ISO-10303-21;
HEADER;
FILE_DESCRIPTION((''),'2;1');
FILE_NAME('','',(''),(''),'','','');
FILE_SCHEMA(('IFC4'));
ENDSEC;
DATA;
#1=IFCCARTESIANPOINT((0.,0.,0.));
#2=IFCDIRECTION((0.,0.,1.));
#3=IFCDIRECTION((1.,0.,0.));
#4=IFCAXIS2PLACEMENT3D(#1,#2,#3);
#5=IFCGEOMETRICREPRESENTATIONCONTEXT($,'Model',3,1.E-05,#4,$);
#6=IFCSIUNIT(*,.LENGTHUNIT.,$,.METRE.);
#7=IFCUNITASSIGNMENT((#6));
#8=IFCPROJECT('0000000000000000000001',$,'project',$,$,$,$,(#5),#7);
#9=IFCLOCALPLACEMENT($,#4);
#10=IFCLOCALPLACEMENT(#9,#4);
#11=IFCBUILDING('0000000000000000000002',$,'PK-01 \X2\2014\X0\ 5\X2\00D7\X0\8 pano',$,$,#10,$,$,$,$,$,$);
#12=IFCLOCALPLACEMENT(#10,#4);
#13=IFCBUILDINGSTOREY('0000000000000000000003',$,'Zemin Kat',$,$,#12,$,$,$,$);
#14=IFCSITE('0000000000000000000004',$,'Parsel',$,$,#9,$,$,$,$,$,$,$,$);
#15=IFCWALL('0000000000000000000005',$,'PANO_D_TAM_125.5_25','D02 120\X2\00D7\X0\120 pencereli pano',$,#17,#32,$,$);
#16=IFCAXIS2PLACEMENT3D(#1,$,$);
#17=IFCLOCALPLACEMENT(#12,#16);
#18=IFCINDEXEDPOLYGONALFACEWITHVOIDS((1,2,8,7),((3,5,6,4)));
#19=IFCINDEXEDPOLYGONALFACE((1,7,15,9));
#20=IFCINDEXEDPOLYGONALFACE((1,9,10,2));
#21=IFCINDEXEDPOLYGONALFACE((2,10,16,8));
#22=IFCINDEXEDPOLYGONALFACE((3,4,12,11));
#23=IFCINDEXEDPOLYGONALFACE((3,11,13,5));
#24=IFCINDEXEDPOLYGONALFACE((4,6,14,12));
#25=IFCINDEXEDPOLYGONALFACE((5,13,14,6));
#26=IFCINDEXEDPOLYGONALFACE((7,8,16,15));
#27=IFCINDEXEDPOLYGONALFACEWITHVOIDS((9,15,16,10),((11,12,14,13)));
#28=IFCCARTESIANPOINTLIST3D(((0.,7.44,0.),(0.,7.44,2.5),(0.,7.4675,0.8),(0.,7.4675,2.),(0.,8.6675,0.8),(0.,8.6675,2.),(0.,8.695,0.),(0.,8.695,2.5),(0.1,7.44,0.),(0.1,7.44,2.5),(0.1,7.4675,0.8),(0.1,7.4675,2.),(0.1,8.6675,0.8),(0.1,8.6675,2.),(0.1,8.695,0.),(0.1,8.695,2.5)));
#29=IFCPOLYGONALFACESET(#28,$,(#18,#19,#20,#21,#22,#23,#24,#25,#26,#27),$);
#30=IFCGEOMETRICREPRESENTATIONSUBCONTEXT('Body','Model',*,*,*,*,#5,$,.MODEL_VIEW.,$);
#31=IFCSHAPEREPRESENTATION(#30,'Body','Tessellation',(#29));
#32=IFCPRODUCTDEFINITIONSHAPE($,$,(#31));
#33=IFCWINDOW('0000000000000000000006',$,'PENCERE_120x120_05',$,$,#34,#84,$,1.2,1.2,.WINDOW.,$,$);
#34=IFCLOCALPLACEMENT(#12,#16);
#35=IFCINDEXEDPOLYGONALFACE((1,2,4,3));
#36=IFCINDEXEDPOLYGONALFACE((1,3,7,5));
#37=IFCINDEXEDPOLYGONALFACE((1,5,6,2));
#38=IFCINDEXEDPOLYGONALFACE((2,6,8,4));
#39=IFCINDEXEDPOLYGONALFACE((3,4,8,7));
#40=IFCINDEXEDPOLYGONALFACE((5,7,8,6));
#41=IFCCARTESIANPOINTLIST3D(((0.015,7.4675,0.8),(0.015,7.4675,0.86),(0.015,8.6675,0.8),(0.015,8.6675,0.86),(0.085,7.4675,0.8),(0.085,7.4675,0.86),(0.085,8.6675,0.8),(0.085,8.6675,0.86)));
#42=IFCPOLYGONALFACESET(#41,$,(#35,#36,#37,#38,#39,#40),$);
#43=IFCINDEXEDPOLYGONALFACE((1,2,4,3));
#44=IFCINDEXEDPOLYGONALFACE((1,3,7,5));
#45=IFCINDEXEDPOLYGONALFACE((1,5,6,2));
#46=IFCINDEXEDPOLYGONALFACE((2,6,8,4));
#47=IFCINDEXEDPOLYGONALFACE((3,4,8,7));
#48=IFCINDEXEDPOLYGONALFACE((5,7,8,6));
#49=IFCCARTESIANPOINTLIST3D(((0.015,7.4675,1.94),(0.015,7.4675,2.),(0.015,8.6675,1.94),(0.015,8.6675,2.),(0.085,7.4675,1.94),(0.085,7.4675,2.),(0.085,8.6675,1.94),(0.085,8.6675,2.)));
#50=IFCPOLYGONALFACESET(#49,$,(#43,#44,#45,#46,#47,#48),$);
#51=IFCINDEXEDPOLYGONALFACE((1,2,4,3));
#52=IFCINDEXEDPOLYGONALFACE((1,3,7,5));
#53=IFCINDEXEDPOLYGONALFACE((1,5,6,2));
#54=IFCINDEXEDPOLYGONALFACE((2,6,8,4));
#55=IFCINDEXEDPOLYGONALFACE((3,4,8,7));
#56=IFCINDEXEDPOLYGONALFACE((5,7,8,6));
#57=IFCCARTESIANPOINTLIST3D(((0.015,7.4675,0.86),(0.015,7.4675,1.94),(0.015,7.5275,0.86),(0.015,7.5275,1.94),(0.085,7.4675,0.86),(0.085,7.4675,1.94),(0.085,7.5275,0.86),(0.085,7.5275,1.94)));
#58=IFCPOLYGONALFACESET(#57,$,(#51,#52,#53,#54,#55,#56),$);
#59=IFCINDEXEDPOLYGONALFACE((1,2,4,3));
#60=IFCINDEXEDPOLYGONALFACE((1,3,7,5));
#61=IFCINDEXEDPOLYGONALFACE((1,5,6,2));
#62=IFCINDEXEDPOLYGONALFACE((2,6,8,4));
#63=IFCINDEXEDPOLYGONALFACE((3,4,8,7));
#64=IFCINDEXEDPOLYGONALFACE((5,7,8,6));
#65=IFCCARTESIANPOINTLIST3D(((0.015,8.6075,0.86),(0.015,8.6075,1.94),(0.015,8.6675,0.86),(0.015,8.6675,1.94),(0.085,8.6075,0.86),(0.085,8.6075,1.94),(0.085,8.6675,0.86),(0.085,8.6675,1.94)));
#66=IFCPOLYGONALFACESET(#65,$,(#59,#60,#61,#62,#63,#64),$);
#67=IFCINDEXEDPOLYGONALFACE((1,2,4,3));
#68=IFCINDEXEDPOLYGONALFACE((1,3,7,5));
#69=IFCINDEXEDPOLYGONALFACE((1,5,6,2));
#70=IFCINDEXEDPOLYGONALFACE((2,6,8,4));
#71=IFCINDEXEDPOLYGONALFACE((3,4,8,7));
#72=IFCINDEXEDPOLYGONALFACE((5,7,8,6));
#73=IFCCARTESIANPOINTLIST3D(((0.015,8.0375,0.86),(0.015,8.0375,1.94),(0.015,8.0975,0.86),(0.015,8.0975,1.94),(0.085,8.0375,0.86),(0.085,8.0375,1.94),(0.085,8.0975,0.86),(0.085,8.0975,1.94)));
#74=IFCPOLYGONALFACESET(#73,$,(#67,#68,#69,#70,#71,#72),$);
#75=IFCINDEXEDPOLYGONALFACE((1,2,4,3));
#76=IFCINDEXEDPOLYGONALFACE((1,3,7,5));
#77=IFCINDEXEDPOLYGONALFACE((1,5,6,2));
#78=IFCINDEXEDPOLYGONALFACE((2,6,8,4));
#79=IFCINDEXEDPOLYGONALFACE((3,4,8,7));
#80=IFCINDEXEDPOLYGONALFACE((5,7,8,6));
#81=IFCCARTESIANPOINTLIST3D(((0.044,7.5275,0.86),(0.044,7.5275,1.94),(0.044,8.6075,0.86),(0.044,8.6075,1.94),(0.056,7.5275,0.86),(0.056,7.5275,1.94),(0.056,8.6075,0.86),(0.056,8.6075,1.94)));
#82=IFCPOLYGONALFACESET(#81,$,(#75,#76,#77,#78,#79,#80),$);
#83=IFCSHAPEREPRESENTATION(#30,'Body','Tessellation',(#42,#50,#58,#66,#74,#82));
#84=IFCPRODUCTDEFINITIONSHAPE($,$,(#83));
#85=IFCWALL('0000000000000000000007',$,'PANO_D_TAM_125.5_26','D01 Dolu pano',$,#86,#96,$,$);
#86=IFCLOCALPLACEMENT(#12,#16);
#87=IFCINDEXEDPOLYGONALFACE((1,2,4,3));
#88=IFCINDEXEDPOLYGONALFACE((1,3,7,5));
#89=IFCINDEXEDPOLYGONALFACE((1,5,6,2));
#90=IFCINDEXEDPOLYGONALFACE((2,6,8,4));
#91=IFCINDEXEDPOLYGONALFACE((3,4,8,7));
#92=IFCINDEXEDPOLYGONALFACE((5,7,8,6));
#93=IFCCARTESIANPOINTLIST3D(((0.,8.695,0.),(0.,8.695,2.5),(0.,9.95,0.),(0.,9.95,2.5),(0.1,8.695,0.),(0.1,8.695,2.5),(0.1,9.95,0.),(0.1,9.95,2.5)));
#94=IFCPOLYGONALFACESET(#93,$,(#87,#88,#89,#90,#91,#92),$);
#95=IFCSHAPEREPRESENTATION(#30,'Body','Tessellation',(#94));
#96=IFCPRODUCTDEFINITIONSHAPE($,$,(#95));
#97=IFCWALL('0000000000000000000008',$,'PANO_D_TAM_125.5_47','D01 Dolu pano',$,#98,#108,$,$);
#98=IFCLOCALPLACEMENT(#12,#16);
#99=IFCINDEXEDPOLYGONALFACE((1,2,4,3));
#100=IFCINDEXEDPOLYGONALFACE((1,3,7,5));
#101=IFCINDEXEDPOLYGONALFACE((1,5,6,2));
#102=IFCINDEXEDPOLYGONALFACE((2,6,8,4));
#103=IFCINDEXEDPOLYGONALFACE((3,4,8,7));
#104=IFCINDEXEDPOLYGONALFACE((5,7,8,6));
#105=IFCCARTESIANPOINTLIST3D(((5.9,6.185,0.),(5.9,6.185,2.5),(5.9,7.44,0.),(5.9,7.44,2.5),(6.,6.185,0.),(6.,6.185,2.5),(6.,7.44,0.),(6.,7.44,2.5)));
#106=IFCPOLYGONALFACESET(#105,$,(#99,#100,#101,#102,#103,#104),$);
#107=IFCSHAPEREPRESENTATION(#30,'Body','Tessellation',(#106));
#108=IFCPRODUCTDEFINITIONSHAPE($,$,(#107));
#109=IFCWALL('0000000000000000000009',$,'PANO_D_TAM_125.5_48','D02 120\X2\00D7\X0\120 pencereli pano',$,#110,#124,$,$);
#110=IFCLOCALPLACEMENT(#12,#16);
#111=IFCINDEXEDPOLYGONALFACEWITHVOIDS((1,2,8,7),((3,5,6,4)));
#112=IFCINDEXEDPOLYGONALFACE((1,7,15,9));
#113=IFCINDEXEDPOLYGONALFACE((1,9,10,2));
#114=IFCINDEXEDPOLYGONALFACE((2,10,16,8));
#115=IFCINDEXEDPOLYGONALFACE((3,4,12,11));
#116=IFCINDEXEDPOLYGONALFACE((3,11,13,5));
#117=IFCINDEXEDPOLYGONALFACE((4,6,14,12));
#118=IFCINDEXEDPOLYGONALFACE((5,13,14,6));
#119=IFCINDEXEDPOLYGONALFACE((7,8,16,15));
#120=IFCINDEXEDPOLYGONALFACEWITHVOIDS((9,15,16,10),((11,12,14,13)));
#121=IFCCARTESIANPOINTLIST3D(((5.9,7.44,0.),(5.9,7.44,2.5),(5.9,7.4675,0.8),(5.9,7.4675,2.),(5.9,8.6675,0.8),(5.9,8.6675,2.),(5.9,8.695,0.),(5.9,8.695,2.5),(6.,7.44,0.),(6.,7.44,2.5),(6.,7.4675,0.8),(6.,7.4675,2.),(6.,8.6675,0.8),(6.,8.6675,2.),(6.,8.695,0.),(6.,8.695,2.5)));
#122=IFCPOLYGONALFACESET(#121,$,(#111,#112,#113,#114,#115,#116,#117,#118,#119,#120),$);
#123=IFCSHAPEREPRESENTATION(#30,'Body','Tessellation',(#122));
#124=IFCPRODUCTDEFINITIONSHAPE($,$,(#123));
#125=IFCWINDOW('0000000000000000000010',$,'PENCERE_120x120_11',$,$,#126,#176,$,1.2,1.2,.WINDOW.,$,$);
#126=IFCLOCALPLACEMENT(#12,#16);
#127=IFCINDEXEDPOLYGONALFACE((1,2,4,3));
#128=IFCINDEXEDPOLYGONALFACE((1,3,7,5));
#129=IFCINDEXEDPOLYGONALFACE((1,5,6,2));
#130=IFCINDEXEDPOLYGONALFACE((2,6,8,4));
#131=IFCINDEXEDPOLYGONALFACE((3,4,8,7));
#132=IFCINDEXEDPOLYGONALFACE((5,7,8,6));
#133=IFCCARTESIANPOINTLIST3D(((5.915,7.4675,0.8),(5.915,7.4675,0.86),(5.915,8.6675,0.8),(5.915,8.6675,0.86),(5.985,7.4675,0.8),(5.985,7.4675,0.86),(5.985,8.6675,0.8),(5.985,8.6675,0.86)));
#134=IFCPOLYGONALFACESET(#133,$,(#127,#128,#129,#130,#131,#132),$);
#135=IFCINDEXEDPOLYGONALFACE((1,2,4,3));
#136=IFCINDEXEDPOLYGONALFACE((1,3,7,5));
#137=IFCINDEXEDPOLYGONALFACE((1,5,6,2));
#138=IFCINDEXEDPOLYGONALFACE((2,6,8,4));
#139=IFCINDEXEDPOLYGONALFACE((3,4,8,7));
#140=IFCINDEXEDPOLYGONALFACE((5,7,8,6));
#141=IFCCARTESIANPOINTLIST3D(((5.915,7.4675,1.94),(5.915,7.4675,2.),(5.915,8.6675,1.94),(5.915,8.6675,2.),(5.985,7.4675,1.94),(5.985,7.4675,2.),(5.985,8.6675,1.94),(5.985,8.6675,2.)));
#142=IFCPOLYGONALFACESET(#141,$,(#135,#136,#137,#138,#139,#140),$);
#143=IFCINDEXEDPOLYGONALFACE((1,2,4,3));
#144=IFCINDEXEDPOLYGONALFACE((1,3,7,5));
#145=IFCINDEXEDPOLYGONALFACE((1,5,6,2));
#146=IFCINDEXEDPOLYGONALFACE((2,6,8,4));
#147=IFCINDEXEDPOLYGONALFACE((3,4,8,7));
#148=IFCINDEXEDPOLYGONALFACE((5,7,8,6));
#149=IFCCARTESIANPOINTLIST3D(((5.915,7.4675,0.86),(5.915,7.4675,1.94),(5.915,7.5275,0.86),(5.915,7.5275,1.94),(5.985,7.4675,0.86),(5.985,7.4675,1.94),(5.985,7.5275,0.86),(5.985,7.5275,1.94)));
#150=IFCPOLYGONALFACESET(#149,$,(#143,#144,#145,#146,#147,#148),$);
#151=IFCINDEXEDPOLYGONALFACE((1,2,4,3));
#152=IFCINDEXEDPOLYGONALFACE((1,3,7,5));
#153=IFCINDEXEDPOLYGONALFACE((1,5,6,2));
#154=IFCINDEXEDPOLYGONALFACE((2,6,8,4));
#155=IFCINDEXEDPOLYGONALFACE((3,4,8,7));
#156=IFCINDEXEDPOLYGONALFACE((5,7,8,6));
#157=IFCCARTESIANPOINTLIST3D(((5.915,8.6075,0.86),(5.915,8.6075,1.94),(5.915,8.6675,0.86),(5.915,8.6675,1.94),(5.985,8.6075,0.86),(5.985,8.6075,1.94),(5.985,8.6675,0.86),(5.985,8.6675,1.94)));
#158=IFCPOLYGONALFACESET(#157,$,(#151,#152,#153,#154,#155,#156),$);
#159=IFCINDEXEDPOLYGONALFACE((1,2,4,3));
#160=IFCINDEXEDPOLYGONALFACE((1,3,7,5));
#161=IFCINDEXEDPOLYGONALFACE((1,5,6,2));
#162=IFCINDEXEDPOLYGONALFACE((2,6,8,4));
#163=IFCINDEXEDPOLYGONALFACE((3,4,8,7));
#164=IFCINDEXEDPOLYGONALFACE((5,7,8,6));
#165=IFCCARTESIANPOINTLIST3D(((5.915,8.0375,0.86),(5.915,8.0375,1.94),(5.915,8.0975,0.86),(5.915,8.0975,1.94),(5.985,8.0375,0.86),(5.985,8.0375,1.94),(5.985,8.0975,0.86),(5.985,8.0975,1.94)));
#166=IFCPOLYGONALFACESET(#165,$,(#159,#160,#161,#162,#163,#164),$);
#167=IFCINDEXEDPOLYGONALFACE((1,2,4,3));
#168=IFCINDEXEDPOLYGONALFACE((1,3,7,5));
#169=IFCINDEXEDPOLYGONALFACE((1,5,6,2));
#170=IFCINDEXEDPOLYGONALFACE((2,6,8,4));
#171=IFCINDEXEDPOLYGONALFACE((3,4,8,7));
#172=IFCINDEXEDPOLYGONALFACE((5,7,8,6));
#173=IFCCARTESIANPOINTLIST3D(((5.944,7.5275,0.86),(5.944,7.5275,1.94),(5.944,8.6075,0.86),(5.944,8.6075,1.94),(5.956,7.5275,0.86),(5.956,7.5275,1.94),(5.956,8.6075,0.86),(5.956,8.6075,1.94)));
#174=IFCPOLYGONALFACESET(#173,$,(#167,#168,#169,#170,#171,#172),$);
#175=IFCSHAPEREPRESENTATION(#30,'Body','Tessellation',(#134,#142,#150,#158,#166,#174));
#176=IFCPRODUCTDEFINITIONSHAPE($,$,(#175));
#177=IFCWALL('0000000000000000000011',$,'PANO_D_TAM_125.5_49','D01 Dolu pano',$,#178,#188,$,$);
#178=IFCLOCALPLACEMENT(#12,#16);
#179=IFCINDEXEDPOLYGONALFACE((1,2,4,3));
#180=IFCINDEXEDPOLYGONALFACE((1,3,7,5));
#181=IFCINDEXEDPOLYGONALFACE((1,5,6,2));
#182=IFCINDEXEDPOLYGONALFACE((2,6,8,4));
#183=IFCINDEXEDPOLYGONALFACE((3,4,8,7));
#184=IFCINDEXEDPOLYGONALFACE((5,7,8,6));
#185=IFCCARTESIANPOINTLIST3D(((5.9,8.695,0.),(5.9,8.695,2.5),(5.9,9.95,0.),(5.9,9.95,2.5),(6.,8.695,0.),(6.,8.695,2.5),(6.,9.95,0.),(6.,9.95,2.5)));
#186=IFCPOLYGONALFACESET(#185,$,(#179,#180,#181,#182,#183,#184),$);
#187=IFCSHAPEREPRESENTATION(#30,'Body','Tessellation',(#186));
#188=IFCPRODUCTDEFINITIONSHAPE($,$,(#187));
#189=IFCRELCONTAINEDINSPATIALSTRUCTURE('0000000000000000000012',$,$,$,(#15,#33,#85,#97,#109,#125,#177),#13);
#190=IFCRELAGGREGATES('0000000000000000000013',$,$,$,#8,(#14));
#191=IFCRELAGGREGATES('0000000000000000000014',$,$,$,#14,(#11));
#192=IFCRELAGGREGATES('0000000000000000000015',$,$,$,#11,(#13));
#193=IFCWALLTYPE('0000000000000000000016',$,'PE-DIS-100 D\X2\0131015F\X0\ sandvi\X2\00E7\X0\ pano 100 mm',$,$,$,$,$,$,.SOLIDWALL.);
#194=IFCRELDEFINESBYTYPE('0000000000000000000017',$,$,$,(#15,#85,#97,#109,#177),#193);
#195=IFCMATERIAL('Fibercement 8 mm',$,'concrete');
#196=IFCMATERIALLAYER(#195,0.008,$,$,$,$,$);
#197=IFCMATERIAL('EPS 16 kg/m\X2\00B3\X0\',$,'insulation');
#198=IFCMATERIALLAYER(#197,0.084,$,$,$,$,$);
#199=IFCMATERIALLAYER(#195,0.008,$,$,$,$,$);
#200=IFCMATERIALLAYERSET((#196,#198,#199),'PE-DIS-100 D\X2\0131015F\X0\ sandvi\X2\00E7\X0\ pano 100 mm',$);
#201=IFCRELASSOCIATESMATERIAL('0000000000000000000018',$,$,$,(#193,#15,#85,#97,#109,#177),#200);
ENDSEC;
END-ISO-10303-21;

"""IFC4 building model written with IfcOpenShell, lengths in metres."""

from ifc_helpers import new_model, si_unit, frame, origin_with_axes, place, context, subcontext, project, spatial, line, indexed_curve, outline, extrude, material, layer, layer_set, layer_usage, type_object, element, fill, save


model = new_model("IFC4")

# Units and contexts
model_context = context("Model", 3, precision=1e-05, world=origin_with_axes())
body_context = subcontext(model_context, "Body", "Model", "MODEL_VIEW")
ifc_project = project(units=[si_unit("LENGTHUNIT", "METRE")], contexts=[model_context])

# Site, building, storey
site_placement = place(None, origin_with_axes())
site = spatial("IfcSite", under=ifc_project, at=site_placement, Name="Parsel")
building_placement = place(site_placement, origin_with_axes())
building = spatial("IfcBuilding", under=site, at=building_placement, Name="PK-01 — 5×8 pano")
storey_placement = place(building_placement, origin_with_axes())
storey = spatial("IfcBuildingStorey", under=building, at=storey_placement, Name="Zemin Kat")

# Shared definitions
ifc_material_1 = material(Name="Fibercement 8 mm", Category="concrete")
ifc_layer_1 = layer(ifc_material_1, 0.008)
ifc_material_2 = material(Name="EPS 16 kg/m³", Category="insulation")
ifc_layer_2 = layer(ifc_material_2, 0.084)
ifc_layer_3 = layer(ifc_material_1, 0.008)
ifc_layer_set_1 = layer_set([ifc_layer_1, ifc_layer_2, ifc_layer_3], Name="PE-DIS-100 Dış sandviç pano 100 mm")
wall_type_1 = type_object("IfcWallType", Name="PE-DIS-100 Dış sandviç pano 100 mm", PredefinedType="SOLIDWALL", material=ifc_layer_set_1)

# Wall, opening, window
ifc_layer_usage_1 = layer_usage(ifc_layer_set_1, "AXIS2", "POSITIVE", 0.0)
wall_1_placement = place(storey_placement, frame((0.1, 7.44, 0.0), z_axis=(0.0, 0.0, 1.0), x_axis=(0.0, 1.0, 0.0)))
wall_1 = element("IfcWall", 1, at=wall_1_placement, inside=storey, type_object=wall_type_1, material=ifc_layer_usage_1, Name="PANO_D_TAM_125.5_25", Description="D02 120×120 pencereli pano", context=body_context, shape_type="SweptSolid", body=[
    extrude(outline(indexed_curve([(0.0, 0.0), (1.255, 0.0), (1.255, 0.1), (0.0, 0.1)], segments=[line(1, 2, 3, 4, 1)])), origin_with_axes(), (0.0, 0.0, 1.0), 2.5),
])
opening_1_placement = place(wall_1_placement, origin_with_axes())
opening_1 = element("IfcOpeningElement", 2, at=opening_1_placement, cuts=wall_1, PredefinedType="OPENING", context=body_context, shape_type="SweptSolid", body=[
    extrude(outline(indexed_curve([(0.0, 0.0), (1.2, 0.0), (1.2, 0.14), (0.0, 0.14)], segments=[line(1, 2, 3, 4, 1)])), frame((0.0275, -0.02, 0.8), z_axis=(0.0, 0.0, 1.0), x_axis=(1.0, 0.0, 0.0)), (0.0, 0.0, 1.0), 1.2),
])
window_1_placement = place(storey_placement, frame((0.1, 7.44, 0.0), z_axis=(0.0, 0.0, 1.0), x_axis=(0.0, 1.0, 0.0)))
window_1 = element("IfcWindow", 3, at=window_1_placement, inside=storey, Name="PENCERE_120x120_05", OverallHeight=1.2, OverallWidth=1.2, PredefinedType="WINDOW", context=body_context, shape_type="SweptSolid", body=[
    extrude(outline(indexed_curve([(0.0, 0.0), (1.2, 0.0), (1.2, 0.07), (0.0, 0.07)], segments=[line(1, 2, 3, 4, 1)])), frame((0.0275, 0.015, 0.8), z_axis=(0.0, 0.0, 1.0), x_axis=(1.0, 0.0, 0.0)), (0.0, 0.0, 1.0), 0.06),
    extrude(outline(indexed_curve([(0.0, 0.0), (1.2, 0.0), (1.2, 0.07), (0.0, 0.07)], segments=[line(1, 2, 3, 4, 1)])), frame((0.0275, 0.015, 1.94), z_axis=(0.0, 0.0, 1.0), x_axis=(1.0, 0.0, 0.0)), (0.0, 0.0, 1.0), 0.06),
    extrude(outline(indexed_curve([(0.0, 0.0), (0.06, 0.0), (0.06, 0.07), (0.0, 0.07)], segments=[line(1, 2, 3, 4, 1)])), frame((0.0275, 0.015, 0.86), z_axis=(0.0, 0.0, 1.0), x_axis=(1.0, 0.0, 0.0)), (0.0, 0.0, 1.0), 1.08),
    extrude(outline(indexed_curve([(0.0, 0.0), (0.06, 0.0), (0.06, 0.07), (0.0, 0.07)], segments=[line(1, 2, 3, 4, 1)])), frame((1.1675, 0.015, 0.86), z_axis=(0.0, 0.0, 1.0), x_axis=(1.0, 0.0, 0.0)), (0.0, 0.0, 1.0), 1.08),
    extrude(outline(indexed_curve([(0.0, 0.0), (0.06, 0.0), (0.06, 0.07), (0.0, 0.07)], segments=[line(1, 2, 3, 4, 1)])), frame((0.5975, 0.015, 0.86), z_axis=(0.0, 0.0, 1.0), x_axis=(1.0, 0.0, 0.0)), (0.0, 0.0, 1.0), 1.08),
    extrude(outline(indexed_curve([(0.0, 0.0), (1.08, 0.0), (1.08, 0.012), (0.0, 0.012)], segments=[line(1, 2, 3, 4, 1)])), frame((0.0875, 0.044, 0.86), z_axis=(0.0, 0.0, 1.0), x_axis=(1.0, 0.0, 0.0)), (0.0, 0.0, 1.0), 1.08),
])
fill(opening_1, window_1)

# Walls
ifc_layer_usage_2 = layer_usage(ifc_layer_set_1, "AXIS2", "POSITIVE", 0.0)
wall_2_placement = place(storey_placement, frame((0.1, 8.695, 0.0), z_axis=(0.0, 0.0, 1.0), x_axis=(0.0, 1.0, 0.0)))
element("IfcWall", 4, at=wall_2_placement, inside=storey, type_object=wall_type_1, material=ifc_layer_usage_2, Name="PANO_D_TAM_125.5_26", Description="D01 Dolu pano", context=body_context, shape_type="SweptSolid", body=[
    extrude(outline(indexed_curve([(0.0, 0.0), (1.255, 0.0), (1.255, 0.1), (0.0, 0.1)], segments=[line(1, 2, 3, 4, 1)])), origin_with_axes(), (0.0, 0.0, 1.0), 2.5),
])
ifc_layer_usage_3 = layer_usage(ifc_layer_set_1, "AXIS2", "POSITIVE", 0.0)
wall_3_placement = place(storey_placement, frame((6.0, 6.185, 0.0), z_axis=(0.0, 0.0, 1.0), x_axis=(0.0, 1.0, 0.0)))
element("IfcWall", 5, at=wall_3_placement, inside=storey, type_object=wall_type_1, material=ifc_layer_usage_3, Name="PANO_D_TAM_125.5_47", Description="D01 Dolu pano", context=body_context, shape_type="SweptSolid", body=[
    extrude(outline(indexed_curve([(0.0, 0.0), (1.255, 0.0), (1.255, 0.1), (0.0, 0.1)], segments=[line(1, 2, 3, 4, 1)])), origin_with_axes(), (0.0, 0.0, 1.0), 2.5),
])

# Wall, opening, window
ifc_layer_usage_4 = layer_usage(ifc_layer_set_1, "AXIS2", "POSITIVE", 0.0)
wall_4_placement = place(storey_placement, frame((6.0, 7.44, 0.0), z_axis=(0.0, 0.0, 1.0), x_axis=(0.0, 1.0, 0.0)))
wall_4 = element("IfcWall", 6, at=wall_4_placement, inside=storey, type_object=wall_type_1, material=ifc_layer_usage_4, Name="PANO_D_TAM_125.5_48", Description="D02 120×120 pencereli pano", context=body_context, shape_type="SweptSolid", body=[
    extrude(outline(indexed_curve([(0.0, 0.0), (1.255, 0.0), (1.255, 0.1), (0.0, 0.1)], segments=[line(1, 2, 3, 4, 1)])), origin_with_axes(), (0.0, 0.0, 1.0), 2.5),
])
opening_2_placement = place(wall_4_placement, origin_with_axes())
opening_2 = element("IfcOpeningElement", 7, at=opening_2_placement, cuts=wall_4, PredefinedType="OPENING", context=body_context, shape_type="SweptSolid", body=[
    extrude(outline(indexed_curve([(0.0, 0.0), (1.2, 0.0), (1.2, 0.14), (0.0, 0.14)], segments=[line(1, 2, 3, 4, 1)])), frame((0.0275, -0.02, 0.8), z_axis=(0.0, 0.0, 1.0), x_axis=(1.0, 0.0, 0.0)), (0.0, 0.0, 1.0), 1.2),
])
window_2_placement = place(storey_placement, frame((6.0, 7.44, 0.0), z_axis=(0.0, 0.0, 1.0), x_axis=(0.0, 1.0, 0.0)))
window_2 = element("IfcWindow", 8, at=window_2_placement, inside=storey, Name="PENCERE_120x120_11", OverallHeight=1.2, OverallWidth=1.2, PredefinedType="WINDOW", context=body_context, shape_type="SweptSolid", body=[
    extrude(outline(indexed_curve([(0.0, 0.0), (1.2, 0.0), (1.2, 0.07), (0.0, 0.07)], segments=[line(1, 2, 3, 4, 1)])), frame((0.0275, 0.015, 0.8), z_axis=(0.0, 0.0, 1.0), x_axis=(1.0, 0.0, 0.0)), (0.0, 0.0, 1.0), 0.06),
    extrude(outline(indexed_curve([(0.0, 0.0), (1.2, 0.0), (1.2, 0.07), (0.0, 0.07)], segments=[line(1, 2, 3, 4, 1)])), frame((0.0275, 0.015, 1.94), z_axis=(0.0, 0.0, 1.0), x_axis=(1.0, 0.0, 0.0)), (0.0, 0.0, 1.0), 0.06),
    extrude(outline(indexed_curve([(0.0, 0.0), (0.06, 0.0), (0.06, 0.07), (0.0, 0.07)], segments=[line(1, 2, 3, 4, 1)])), frame((0.0275, 0.015, 0.86), z_axis=(0.0, 0.0, 1.0), x_axis=(1.0, 0.0, 0.0)), (0.0, 0.0, 1.0), 1.08),
    extrude(outline(indexed_curve([(0.0, 0.0), (0.06, 0.0), (0.06, 0.07), (0.0, 0.07)], segments=[line(1, 2, 3, 4, 1)])), frame((1.1675, 0.015, 0.86), z_axis=(0.0, 0.0, 1.0), x_axis=(1.0, 0.0, 0.0)), (0.0, 0.0, 1.0), 1.08),
    extrude(outline(indexed_curve([(0.0, 0.0), (0.06, 0.0), (0.06, 0.07), (0.0, 0.07)], segments=[line(1, 2, 3, 4, 1)])), frame((0.5975, 0.015, 0.86), z_axis=(0.0, 0.0, 1.0), x_axis=(1.0, 0.0, 0.0)), (0.0, 0.0, 1.0), 1.08),
    extrude(outline(indexed_curve([(0.0, 0.0), (1.08, 0.0), (1.08, 0.012), (0.0, 0.012)], segments=[line(1, 2, 3, 4, 1)])), frame((0.0875, 0.044, 0.86), z_axis=(0.0, 0.0, 1.0), x_axis=(1.0, 0.0, 0.0)), (0.0, 0.0, 1.0), 1.08),
])
fill(opening_2, window_2)

# Wall
ifc_layer_usage_5 = layer_usage(ifc_layer_set_1, "AXIS2", "POSITIVE", 0.0)
wall_5_placement = place(storey_placement, frame((6.0, 8.695, 0.0), z_axis=(0.0, 0.0, 1.0), x_axis=(0.0, 1.0, 0.0)))
element("IfcWall", 9, at=wall_5_placement, inside=storey, type_object=wall_type_1, material=ifc_layer_usage_5, Name="PANO_D_TAM_125.5_49", Description="D01 Dolu pano", context=body_context, shape_type="SweptSolid", body=[
    extrude(outline(indexed_curve([(0.0, 0.0), (1.255, 0.0), (1.255, 0.1), (0.0, 0.1)], segments=[line(1, 2, 3, 4, 1)])), origin_with_axes(), (0.0, 0.0, 1.0), 2.5),
])

save(model, "model.ifc")
